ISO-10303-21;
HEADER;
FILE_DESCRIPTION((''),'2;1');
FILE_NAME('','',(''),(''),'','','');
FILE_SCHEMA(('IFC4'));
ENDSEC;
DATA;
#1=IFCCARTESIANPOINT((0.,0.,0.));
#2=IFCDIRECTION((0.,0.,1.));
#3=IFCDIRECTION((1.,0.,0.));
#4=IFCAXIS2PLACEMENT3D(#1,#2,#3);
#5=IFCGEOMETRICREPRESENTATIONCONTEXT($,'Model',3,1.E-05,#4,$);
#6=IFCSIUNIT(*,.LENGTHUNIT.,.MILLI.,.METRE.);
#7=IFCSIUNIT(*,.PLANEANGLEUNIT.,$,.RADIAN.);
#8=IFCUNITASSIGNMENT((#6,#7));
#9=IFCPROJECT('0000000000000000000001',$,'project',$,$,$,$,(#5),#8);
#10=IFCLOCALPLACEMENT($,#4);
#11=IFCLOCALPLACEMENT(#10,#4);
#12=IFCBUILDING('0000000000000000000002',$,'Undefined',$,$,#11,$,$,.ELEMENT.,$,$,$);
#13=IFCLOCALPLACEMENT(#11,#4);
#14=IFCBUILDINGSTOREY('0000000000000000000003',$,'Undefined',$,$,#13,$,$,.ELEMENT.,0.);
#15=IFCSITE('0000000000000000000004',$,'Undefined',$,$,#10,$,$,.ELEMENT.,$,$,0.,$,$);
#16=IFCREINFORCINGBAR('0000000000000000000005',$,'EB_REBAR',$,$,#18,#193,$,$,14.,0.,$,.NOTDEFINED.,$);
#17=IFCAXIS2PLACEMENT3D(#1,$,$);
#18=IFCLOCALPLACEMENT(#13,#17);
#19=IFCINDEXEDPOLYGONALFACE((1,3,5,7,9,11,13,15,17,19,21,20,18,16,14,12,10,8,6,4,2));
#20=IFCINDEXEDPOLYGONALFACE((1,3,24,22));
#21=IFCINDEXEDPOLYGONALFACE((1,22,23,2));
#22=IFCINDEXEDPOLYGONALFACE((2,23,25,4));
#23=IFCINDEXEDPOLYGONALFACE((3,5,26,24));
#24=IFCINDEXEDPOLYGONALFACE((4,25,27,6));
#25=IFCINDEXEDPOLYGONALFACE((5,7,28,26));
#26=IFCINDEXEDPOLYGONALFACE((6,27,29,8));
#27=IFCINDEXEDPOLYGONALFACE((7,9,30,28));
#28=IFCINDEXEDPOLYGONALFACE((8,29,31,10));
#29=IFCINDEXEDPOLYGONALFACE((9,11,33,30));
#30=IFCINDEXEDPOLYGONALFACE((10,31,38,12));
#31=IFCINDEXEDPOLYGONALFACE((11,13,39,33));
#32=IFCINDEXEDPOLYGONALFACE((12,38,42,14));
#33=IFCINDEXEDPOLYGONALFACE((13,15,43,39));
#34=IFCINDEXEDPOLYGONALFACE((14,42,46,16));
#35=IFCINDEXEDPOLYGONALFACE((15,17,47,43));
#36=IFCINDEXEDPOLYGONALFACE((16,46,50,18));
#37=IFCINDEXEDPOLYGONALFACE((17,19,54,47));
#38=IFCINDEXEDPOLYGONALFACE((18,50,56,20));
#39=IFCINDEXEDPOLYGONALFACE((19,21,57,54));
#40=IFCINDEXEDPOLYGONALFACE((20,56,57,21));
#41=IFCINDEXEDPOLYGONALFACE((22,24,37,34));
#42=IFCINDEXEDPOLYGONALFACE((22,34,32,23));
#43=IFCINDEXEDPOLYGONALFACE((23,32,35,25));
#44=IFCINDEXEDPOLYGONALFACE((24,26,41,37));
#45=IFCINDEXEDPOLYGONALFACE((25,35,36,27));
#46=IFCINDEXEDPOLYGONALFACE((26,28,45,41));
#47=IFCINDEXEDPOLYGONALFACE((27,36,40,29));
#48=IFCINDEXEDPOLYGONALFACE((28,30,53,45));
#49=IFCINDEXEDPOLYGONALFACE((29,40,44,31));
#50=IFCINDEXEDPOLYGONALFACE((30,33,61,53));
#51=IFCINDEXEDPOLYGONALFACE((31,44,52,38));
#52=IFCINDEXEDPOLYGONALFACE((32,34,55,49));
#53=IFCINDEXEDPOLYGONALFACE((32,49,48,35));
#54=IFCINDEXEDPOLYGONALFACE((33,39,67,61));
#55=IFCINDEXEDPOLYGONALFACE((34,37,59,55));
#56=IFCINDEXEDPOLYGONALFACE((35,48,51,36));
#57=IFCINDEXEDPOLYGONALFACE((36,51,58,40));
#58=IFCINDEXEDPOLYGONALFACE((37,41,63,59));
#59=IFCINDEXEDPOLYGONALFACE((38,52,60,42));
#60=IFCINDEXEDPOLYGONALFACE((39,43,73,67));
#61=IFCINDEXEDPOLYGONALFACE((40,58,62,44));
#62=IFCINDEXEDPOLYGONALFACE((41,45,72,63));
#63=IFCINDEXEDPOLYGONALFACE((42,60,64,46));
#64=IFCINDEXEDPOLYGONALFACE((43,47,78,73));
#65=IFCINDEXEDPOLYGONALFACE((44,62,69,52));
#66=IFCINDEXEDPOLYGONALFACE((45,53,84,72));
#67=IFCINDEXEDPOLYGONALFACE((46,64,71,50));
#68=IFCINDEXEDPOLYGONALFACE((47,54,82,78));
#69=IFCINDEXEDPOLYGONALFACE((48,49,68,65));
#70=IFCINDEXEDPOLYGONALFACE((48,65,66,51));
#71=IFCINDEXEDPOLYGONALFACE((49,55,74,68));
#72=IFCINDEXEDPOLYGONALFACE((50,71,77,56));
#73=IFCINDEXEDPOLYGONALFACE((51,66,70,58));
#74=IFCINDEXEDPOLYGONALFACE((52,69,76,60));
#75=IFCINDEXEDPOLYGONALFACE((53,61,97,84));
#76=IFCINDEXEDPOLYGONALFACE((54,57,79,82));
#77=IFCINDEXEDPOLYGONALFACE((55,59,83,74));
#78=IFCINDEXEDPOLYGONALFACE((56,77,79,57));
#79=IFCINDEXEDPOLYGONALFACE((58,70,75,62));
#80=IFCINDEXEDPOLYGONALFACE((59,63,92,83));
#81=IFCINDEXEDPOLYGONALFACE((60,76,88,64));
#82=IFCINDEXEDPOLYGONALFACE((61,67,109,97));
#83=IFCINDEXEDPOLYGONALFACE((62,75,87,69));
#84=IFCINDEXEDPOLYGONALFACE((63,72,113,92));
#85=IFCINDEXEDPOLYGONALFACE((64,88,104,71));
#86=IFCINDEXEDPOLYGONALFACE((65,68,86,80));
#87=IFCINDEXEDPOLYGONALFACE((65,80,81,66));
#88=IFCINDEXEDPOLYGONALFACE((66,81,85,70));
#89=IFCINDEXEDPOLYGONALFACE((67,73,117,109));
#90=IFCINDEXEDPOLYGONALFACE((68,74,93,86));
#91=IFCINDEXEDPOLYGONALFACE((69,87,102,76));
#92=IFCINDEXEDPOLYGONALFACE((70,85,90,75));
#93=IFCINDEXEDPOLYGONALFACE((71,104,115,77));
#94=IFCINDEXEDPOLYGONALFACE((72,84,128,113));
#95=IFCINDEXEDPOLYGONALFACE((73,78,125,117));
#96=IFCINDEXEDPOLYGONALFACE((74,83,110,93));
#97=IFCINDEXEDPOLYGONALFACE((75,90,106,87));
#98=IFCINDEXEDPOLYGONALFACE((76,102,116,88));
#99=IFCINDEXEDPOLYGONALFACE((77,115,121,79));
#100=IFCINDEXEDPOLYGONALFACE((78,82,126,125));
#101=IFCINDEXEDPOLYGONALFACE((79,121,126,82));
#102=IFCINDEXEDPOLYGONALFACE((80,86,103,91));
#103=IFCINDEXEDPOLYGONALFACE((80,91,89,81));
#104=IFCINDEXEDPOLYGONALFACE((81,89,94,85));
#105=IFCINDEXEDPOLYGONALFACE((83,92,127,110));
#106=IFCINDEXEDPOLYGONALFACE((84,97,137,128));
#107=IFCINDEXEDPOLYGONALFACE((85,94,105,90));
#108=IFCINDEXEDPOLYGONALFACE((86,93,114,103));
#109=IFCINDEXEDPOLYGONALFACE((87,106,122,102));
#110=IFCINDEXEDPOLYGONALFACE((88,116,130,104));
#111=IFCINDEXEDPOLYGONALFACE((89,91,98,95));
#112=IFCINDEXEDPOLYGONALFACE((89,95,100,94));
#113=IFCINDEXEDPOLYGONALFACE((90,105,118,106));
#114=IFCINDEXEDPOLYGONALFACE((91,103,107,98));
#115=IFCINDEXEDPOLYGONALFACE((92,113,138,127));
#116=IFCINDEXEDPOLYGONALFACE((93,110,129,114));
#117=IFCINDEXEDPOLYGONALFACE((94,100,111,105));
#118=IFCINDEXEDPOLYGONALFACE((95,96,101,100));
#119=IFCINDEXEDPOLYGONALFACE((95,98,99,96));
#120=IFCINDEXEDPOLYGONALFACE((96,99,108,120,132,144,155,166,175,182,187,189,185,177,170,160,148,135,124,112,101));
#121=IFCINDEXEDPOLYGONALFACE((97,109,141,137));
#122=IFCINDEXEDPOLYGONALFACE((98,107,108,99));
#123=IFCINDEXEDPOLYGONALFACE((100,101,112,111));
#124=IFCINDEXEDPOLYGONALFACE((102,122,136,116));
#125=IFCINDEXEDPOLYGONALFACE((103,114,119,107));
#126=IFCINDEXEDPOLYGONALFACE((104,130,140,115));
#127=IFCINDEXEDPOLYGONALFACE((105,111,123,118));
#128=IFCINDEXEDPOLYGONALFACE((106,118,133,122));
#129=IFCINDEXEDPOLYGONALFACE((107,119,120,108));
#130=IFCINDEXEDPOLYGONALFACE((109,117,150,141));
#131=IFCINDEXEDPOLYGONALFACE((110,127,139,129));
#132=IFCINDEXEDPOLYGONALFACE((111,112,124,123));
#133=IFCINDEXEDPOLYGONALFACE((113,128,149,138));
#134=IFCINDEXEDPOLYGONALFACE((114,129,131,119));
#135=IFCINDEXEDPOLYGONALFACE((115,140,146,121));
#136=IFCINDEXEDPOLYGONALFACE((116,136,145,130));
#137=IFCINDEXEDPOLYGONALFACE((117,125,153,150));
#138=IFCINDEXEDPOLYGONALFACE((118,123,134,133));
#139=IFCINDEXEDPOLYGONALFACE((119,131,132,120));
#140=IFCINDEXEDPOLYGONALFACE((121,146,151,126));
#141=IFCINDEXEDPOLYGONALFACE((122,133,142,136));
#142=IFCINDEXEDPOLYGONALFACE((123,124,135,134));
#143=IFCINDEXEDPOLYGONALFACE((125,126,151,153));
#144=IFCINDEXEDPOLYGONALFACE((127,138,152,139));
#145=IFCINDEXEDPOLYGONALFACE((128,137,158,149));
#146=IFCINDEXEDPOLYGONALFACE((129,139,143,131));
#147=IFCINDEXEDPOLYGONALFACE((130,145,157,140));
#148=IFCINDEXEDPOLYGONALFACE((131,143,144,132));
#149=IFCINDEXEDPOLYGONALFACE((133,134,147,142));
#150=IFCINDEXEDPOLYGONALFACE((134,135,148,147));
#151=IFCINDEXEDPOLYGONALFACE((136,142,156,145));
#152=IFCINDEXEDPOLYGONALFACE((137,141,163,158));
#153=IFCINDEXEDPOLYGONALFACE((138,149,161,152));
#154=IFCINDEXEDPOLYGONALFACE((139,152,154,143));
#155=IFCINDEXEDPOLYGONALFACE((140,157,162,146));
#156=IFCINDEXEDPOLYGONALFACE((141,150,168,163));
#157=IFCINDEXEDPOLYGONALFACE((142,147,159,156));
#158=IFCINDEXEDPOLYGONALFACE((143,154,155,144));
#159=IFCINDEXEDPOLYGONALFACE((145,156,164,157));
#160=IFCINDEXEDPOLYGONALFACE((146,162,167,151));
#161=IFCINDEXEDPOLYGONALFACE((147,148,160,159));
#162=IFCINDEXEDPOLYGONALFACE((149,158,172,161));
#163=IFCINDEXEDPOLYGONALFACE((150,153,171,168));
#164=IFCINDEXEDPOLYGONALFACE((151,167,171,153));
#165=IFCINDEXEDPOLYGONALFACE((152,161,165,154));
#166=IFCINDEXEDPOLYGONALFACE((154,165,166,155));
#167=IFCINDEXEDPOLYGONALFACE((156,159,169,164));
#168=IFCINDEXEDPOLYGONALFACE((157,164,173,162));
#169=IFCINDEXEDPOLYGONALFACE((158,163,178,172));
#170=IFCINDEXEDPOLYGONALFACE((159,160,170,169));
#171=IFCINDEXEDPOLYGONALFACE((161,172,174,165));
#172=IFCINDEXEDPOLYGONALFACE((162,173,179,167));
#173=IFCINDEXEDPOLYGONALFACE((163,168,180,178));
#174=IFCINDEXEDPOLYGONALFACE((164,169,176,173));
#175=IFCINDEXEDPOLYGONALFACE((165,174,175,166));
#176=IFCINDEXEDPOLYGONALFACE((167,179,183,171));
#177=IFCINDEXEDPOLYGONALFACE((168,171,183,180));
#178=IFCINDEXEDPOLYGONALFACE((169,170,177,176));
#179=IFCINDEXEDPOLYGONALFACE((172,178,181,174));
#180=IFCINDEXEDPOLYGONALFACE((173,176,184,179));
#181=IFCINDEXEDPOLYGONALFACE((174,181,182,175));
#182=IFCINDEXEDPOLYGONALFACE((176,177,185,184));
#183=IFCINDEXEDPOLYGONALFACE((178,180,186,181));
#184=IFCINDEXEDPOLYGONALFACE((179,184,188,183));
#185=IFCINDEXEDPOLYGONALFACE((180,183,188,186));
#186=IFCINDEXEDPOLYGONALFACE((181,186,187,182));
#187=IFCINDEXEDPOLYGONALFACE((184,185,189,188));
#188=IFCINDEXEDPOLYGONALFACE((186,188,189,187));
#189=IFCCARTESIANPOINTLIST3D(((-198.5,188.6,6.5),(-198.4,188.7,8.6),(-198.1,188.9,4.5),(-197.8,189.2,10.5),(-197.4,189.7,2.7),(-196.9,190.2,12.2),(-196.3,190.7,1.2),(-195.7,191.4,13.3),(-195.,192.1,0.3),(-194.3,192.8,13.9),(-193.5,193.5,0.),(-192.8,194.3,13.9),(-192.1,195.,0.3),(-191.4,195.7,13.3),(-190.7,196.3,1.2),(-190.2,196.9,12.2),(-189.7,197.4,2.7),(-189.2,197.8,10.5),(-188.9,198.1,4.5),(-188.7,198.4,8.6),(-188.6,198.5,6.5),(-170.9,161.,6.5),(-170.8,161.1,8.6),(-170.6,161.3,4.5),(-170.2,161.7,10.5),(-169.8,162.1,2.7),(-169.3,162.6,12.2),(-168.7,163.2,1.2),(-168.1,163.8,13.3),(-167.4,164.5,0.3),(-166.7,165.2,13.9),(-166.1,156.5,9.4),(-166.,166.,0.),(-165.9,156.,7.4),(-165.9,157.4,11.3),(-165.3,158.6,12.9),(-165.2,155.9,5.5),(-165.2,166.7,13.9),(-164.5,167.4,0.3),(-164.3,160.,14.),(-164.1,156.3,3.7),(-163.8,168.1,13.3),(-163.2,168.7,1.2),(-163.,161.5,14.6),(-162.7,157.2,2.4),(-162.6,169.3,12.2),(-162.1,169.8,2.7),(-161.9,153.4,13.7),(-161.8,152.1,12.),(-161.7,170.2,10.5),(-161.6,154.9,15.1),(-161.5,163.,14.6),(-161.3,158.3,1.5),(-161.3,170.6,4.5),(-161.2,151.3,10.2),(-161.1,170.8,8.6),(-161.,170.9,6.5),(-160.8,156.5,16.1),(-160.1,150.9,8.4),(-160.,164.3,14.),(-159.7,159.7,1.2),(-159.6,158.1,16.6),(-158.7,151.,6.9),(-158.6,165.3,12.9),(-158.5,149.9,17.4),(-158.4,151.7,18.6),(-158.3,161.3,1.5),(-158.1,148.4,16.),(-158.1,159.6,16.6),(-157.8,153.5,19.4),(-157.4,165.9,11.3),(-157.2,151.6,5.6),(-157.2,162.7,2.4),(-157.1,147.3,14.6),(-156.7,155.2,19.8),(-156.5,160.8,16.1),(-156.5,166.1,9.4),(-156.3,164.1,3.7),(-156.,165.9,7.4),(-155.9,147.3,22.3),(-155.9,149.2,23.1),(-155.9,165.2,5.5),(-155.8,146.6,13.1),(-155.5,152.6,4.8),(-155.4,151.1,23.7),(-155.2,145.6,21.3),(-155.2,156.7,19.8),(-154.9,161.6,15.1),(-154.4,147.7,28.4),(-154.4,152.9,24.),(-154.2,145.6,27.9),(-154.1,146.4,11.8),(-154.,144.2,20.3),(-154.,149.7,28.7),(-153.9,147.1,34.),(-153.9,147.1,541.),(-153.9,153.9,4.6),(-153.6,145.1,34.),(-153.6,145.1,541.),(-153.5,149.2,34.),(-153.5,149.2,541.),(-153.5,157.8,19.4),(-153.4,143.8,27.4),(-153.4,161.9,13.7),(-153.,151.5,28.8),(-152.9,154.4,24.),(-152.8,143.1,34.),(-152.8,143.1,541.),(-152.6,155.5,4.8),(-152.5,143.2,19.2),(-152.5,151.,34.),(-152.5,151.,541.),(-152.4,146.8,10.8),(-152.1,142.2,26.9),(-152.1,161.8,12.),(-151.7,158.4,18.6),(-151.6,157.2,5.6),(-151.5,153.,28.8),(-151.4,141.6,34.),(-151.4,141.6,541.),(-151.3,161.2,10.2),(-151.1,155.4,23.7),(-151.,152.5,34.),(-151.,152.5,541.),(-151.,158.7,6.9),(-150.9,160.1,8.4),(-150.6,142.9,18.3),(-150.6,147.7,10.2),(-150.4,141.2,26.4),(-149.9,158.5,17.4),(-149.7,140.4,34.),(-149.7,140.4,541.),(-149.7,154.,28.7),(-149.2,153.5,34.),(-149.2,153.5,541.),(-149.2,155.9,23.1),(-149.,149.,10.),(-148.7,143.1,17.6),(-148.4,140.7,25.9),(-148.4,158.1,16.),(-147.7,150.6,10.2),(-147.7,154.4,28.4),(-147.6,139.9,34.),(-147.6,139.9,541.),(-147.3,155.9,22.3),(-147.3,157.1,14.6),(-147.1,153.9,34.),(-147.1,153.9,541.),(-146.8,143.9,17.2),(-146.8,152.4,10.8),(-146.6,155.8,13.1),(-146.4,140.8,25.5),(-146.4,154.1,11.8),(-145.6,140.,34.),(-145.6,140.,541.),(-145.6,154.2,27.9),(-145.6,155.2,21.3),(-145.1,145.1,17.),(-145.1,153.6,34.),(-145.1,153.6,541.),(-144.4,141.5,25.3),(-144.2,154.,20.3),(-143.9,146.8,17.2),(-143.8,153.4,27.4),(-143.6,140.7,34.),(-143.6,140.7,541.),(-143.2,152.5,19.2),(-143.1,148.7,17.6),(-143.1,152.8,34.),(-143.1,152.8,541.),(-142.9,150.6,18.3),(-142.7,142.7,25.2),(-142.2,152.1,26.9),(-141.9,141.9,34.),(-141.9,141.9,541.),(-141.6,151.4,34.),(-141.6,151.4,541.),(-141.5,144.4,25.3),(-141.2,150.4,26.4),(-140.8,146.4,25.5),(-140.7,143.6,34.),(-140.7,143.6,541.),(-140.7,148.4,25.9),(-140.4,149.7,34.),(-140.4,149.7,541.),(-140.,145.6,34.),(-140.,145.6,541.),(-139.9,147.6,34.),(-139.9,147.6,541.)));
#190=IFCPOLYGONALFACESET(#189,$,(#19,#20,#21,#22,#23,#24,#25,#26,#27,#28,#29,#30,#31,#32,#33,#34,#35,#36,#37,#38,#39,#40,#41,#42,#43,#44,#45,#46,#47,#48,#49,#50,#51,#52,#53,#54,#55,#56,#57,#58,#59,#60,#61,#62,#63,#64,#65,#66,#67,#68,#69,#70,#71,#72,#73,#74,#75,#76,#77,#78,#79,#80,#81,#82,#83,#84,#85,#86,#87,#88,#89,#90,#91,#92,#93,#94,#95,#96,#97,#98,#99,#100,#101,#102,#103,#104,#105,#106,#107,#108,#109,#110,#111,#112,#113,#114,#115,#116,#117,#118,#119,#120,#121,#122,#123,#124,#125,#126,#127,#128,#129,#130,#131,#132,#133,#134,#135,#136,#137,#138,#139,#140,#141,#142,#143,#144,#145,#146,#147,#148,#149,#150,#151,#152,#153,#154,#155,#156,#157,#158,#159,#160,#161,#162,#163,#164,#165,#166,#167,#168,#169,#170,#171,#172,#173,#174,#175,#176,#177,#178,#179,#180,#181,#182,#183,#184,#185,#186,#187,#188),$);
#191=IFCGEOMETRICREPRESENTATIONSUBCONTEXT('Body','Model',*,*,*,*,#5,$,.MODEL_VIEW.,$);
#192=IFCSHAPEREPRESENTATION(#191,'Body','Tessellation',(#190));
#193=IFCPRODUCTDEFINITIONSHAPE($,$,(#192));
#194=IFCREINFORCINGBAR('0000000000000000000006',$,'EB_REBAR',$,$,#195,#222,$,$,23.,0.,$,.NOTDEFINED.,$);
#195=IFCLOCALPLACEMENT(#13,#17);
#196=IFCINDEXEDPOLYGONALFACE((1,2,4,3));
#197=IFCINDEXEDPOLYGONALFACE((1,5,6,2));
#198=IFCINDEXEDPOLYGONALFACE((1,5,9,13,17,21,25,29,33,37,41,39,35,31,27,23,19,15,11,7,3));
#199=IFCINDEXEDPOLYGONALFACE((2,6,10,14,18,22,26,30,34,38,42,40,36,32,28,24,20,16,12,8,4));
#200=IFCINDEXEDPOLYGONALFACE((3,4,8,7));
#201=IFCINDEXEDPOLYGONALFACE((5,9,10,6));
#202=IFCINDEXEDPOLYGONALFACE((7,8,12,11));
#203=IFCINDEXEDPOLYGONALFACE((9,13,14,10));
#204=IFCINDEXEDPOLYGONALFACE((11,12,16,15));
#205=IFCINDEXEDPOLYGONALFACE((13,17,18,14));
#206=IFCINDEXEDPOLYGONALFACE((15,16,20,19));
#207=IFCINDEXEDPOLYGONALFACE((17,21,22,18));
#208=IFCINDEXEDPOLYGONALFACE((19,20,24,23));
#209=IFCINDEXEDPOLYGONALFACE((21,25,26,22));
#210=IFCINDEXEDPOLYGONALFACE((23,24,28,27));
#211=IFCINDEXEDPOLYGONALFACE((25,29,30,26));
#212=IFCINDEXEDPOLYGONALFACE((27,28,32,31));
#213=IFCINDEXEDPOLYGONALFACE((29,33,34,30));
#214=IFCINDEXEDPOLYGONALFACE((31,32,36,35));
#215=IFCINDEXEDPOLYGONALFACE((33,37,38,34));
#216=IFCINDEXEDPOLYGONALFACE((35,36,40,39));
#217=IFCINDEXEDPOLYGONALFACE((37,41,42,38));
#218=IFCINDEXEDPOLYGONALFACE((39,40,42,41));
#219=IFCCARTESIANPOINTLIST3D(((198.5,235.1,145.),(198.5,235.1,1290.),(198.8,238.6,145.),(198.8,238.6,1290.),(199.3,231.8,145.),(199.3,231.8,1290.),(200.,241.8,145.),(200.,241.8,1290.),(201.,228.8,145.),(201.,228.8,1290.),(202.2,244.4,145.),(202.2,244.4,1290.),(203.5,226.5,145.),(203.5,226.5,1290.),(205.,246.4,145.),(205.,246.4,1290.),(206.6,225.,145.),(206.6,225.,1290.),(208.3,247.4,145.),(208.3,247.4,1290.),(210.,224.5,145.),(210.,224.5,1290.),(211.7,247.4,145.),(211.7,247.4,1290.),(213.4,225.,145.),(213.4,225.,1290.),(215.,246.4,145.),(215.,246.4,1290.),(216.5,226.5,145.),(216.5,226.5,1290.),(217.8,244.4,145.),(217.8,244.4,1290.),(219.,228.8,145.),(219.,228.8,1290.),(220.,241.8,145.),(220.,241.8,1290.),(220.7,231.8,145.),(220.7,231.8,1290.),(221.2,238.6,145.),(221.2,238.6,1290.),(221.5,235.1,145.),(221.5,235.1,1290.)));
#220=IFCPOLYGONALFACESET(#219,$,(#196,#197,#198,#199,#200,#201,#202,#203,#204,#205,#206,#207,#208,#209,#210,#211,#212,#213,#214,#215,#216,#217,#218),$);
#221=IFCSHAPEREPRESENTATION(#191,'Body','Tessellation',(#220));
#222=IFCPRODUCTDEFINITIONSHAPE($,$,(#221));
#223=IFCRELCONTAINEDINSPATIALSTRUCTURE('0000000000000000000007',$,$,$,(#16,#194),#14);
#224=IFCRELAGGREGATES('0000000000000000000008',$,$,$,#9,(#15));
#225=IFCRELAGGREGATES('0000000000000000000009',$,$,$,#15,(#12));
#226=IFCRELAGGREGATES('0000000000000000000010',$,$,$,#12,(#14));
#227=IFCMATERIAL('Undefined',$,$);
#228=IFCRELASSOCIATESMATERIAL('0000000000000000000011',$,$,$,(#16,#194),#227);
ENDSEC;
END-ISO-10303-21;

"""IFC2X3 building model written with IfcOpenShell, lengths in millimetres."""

from ifc_helpers import new_model, entity, si_unit, frame, origin_with_axes, place, context, subcontext, project, spatial, source, transform, mapped, material, element, save


model = new_model("IFC2X3")

# Units and contexts
model_context = context("Model", 3, precision=1e-05, world=origin_with_axes())
body_context = subcontext(model_context, "Body", "Model", "MODEL_VIEW")
ifc_project = project(units=[si_unit("LENGTHUNIT", "METRE", prefix="MILLI"), si_unit("PLANEANGLEUNIT", "RADIAN")], contexts=[model_context])

# Site, building, storey
site_placement = place(None, origin_with_axes())
site = spatial("IfcSite", under=ifc_project, at=site_placement, Name="Undefined", CompositionType="ELEMENT", RefElevation=0.0)
building_placement = place(site_placement, origin_with_axes())
building = spatial("IfcBuilding", under=site, at=building_placement, Name="Undefined", CompositionType="ELEMENT")
storey_placement = place(building_placement, origin_with_axes())
storey = spatial("IfcBuildingStorey", under=building, at=storey_placement, Name="Undefined", CompositionType="ELEMENT", Elevation=0.0)

# Reinforcing bars
ifc_material_1 = material(Name="Undefined")
shared_shape_1 = source(origin_with_axes(), body_context, "Body", "AdvancedSweptSolid", [
    entity("IfcSweptDiskSolid", entity("IfcCompositeCurve", [entity("IfcCompositeCurveSegment", "CONTINUOUS", True, entity("IfcTrimmedCurve", entity("IfcLine", entity("IfcCartesianPoint", [0.0, 0.0, 0.0]), entity("IfcVector", entity("IfcDirection", [0.0, 0.0, -1.0]), 1.0)), [entity("IfcParameterValue", 0.0)], [entity("IfcParameterValue", 39.002617)], True, "PARAMETER")), entity("IfcCompositeCurveSegment", "CONTINUOUS", True, entity("IfcTrimmedCurve", entity("IfcCircle", entity("IfcAxis2Placement3D", entity("IfcCartesianPoint", [27.0, 0.0, -39.0]), entity("IfcDirection", [0.0, -1.0, 0.0]), entity("IfcDirection", [-1.0, 0.0, 0.0])), 27.0), [entity("IfcParameterValue", 0.0)], [entity("IfcParameterValue", 1.570797)], True, "PARAMETER")), entity("IfcCompositeCurveSegment", "DISCONTINUOUS", True, entity("IfcTrimmedCurve", entity("IfcLine", entity("IfcCartesianPoint", [27.0, 0.0, -66.0]), entity("IfcVector", entity("IfcDirection", [1.0, 0.0, 0.0]), 1.0)), [entity("IfcParameterValue", 0.0)], [entity("IfcParameterValue", 506.999983)], True, "PARAMETER"))], False), 7.0, None, 0.0, 547.6),
])
reinforcing_bar_1_placement = place(storey_placement, frame((-155.9, 155.9, 7.0), z_axis=(-0.707107, 0.707107, 0.000001), x_axis=(0.000001, -0.000001, 1.0)))
element("IfcReinforcingBar", 1, at=reinforcing_bar_1_placement, inside=storey, material=ifc_material_1, Name="EB_REBAR", BarRole="NOTDEFINED", CrossSectionArea=0.0, NominalDiameter=14.0, context=body_context, shape_type="MappedRepresentation", body=[
    mapped(shared_shape_1, transform((0.0, 0.0, 53.2))),
])
shared_shape_2 = source(origin_with_axes(), body_context, "Body", "AdvancedSweptSolid", [
    entity("IfcSweptDiskSolid", entity("IfcTrimmedCurve", entity("IfcLine", entity("IfcCartesianPoint", [0.0, 0.0, 0.0]), entity("IfcVector", entity("IfcDirection", [1.0, 0.0, 0.0]), 1.0)), [entity("IfcParameterValue", 0.0)], [entity("IfcParameterValue", 1144.999881)], True, "PARAMETER"), 11.5, None, 0.0, 1145.0),
])
reinforcing_bar_2_placement = place(storey_placement, frame((210.0, 236.0, 145.0), z_axis=(0.0, -1.0, 0.0), x_axis=(0.0, 0.0, 1.0)))
element("IfcReinforcingBar", 2, at=reinforcing_bar_2_placement, inside=storey, material=ifc_material_1, Name="EB_REBAR", BarRole="NOTDEFINED", CrossSectionArea=0.0, NominalDiameter=23.0, context=body_context, shape_type="MappedRepresentation", body=[
    mapped(shared_shape_2, transform((0.0, 0.0, 0.0))),
])

save(model, "model.ifc")
